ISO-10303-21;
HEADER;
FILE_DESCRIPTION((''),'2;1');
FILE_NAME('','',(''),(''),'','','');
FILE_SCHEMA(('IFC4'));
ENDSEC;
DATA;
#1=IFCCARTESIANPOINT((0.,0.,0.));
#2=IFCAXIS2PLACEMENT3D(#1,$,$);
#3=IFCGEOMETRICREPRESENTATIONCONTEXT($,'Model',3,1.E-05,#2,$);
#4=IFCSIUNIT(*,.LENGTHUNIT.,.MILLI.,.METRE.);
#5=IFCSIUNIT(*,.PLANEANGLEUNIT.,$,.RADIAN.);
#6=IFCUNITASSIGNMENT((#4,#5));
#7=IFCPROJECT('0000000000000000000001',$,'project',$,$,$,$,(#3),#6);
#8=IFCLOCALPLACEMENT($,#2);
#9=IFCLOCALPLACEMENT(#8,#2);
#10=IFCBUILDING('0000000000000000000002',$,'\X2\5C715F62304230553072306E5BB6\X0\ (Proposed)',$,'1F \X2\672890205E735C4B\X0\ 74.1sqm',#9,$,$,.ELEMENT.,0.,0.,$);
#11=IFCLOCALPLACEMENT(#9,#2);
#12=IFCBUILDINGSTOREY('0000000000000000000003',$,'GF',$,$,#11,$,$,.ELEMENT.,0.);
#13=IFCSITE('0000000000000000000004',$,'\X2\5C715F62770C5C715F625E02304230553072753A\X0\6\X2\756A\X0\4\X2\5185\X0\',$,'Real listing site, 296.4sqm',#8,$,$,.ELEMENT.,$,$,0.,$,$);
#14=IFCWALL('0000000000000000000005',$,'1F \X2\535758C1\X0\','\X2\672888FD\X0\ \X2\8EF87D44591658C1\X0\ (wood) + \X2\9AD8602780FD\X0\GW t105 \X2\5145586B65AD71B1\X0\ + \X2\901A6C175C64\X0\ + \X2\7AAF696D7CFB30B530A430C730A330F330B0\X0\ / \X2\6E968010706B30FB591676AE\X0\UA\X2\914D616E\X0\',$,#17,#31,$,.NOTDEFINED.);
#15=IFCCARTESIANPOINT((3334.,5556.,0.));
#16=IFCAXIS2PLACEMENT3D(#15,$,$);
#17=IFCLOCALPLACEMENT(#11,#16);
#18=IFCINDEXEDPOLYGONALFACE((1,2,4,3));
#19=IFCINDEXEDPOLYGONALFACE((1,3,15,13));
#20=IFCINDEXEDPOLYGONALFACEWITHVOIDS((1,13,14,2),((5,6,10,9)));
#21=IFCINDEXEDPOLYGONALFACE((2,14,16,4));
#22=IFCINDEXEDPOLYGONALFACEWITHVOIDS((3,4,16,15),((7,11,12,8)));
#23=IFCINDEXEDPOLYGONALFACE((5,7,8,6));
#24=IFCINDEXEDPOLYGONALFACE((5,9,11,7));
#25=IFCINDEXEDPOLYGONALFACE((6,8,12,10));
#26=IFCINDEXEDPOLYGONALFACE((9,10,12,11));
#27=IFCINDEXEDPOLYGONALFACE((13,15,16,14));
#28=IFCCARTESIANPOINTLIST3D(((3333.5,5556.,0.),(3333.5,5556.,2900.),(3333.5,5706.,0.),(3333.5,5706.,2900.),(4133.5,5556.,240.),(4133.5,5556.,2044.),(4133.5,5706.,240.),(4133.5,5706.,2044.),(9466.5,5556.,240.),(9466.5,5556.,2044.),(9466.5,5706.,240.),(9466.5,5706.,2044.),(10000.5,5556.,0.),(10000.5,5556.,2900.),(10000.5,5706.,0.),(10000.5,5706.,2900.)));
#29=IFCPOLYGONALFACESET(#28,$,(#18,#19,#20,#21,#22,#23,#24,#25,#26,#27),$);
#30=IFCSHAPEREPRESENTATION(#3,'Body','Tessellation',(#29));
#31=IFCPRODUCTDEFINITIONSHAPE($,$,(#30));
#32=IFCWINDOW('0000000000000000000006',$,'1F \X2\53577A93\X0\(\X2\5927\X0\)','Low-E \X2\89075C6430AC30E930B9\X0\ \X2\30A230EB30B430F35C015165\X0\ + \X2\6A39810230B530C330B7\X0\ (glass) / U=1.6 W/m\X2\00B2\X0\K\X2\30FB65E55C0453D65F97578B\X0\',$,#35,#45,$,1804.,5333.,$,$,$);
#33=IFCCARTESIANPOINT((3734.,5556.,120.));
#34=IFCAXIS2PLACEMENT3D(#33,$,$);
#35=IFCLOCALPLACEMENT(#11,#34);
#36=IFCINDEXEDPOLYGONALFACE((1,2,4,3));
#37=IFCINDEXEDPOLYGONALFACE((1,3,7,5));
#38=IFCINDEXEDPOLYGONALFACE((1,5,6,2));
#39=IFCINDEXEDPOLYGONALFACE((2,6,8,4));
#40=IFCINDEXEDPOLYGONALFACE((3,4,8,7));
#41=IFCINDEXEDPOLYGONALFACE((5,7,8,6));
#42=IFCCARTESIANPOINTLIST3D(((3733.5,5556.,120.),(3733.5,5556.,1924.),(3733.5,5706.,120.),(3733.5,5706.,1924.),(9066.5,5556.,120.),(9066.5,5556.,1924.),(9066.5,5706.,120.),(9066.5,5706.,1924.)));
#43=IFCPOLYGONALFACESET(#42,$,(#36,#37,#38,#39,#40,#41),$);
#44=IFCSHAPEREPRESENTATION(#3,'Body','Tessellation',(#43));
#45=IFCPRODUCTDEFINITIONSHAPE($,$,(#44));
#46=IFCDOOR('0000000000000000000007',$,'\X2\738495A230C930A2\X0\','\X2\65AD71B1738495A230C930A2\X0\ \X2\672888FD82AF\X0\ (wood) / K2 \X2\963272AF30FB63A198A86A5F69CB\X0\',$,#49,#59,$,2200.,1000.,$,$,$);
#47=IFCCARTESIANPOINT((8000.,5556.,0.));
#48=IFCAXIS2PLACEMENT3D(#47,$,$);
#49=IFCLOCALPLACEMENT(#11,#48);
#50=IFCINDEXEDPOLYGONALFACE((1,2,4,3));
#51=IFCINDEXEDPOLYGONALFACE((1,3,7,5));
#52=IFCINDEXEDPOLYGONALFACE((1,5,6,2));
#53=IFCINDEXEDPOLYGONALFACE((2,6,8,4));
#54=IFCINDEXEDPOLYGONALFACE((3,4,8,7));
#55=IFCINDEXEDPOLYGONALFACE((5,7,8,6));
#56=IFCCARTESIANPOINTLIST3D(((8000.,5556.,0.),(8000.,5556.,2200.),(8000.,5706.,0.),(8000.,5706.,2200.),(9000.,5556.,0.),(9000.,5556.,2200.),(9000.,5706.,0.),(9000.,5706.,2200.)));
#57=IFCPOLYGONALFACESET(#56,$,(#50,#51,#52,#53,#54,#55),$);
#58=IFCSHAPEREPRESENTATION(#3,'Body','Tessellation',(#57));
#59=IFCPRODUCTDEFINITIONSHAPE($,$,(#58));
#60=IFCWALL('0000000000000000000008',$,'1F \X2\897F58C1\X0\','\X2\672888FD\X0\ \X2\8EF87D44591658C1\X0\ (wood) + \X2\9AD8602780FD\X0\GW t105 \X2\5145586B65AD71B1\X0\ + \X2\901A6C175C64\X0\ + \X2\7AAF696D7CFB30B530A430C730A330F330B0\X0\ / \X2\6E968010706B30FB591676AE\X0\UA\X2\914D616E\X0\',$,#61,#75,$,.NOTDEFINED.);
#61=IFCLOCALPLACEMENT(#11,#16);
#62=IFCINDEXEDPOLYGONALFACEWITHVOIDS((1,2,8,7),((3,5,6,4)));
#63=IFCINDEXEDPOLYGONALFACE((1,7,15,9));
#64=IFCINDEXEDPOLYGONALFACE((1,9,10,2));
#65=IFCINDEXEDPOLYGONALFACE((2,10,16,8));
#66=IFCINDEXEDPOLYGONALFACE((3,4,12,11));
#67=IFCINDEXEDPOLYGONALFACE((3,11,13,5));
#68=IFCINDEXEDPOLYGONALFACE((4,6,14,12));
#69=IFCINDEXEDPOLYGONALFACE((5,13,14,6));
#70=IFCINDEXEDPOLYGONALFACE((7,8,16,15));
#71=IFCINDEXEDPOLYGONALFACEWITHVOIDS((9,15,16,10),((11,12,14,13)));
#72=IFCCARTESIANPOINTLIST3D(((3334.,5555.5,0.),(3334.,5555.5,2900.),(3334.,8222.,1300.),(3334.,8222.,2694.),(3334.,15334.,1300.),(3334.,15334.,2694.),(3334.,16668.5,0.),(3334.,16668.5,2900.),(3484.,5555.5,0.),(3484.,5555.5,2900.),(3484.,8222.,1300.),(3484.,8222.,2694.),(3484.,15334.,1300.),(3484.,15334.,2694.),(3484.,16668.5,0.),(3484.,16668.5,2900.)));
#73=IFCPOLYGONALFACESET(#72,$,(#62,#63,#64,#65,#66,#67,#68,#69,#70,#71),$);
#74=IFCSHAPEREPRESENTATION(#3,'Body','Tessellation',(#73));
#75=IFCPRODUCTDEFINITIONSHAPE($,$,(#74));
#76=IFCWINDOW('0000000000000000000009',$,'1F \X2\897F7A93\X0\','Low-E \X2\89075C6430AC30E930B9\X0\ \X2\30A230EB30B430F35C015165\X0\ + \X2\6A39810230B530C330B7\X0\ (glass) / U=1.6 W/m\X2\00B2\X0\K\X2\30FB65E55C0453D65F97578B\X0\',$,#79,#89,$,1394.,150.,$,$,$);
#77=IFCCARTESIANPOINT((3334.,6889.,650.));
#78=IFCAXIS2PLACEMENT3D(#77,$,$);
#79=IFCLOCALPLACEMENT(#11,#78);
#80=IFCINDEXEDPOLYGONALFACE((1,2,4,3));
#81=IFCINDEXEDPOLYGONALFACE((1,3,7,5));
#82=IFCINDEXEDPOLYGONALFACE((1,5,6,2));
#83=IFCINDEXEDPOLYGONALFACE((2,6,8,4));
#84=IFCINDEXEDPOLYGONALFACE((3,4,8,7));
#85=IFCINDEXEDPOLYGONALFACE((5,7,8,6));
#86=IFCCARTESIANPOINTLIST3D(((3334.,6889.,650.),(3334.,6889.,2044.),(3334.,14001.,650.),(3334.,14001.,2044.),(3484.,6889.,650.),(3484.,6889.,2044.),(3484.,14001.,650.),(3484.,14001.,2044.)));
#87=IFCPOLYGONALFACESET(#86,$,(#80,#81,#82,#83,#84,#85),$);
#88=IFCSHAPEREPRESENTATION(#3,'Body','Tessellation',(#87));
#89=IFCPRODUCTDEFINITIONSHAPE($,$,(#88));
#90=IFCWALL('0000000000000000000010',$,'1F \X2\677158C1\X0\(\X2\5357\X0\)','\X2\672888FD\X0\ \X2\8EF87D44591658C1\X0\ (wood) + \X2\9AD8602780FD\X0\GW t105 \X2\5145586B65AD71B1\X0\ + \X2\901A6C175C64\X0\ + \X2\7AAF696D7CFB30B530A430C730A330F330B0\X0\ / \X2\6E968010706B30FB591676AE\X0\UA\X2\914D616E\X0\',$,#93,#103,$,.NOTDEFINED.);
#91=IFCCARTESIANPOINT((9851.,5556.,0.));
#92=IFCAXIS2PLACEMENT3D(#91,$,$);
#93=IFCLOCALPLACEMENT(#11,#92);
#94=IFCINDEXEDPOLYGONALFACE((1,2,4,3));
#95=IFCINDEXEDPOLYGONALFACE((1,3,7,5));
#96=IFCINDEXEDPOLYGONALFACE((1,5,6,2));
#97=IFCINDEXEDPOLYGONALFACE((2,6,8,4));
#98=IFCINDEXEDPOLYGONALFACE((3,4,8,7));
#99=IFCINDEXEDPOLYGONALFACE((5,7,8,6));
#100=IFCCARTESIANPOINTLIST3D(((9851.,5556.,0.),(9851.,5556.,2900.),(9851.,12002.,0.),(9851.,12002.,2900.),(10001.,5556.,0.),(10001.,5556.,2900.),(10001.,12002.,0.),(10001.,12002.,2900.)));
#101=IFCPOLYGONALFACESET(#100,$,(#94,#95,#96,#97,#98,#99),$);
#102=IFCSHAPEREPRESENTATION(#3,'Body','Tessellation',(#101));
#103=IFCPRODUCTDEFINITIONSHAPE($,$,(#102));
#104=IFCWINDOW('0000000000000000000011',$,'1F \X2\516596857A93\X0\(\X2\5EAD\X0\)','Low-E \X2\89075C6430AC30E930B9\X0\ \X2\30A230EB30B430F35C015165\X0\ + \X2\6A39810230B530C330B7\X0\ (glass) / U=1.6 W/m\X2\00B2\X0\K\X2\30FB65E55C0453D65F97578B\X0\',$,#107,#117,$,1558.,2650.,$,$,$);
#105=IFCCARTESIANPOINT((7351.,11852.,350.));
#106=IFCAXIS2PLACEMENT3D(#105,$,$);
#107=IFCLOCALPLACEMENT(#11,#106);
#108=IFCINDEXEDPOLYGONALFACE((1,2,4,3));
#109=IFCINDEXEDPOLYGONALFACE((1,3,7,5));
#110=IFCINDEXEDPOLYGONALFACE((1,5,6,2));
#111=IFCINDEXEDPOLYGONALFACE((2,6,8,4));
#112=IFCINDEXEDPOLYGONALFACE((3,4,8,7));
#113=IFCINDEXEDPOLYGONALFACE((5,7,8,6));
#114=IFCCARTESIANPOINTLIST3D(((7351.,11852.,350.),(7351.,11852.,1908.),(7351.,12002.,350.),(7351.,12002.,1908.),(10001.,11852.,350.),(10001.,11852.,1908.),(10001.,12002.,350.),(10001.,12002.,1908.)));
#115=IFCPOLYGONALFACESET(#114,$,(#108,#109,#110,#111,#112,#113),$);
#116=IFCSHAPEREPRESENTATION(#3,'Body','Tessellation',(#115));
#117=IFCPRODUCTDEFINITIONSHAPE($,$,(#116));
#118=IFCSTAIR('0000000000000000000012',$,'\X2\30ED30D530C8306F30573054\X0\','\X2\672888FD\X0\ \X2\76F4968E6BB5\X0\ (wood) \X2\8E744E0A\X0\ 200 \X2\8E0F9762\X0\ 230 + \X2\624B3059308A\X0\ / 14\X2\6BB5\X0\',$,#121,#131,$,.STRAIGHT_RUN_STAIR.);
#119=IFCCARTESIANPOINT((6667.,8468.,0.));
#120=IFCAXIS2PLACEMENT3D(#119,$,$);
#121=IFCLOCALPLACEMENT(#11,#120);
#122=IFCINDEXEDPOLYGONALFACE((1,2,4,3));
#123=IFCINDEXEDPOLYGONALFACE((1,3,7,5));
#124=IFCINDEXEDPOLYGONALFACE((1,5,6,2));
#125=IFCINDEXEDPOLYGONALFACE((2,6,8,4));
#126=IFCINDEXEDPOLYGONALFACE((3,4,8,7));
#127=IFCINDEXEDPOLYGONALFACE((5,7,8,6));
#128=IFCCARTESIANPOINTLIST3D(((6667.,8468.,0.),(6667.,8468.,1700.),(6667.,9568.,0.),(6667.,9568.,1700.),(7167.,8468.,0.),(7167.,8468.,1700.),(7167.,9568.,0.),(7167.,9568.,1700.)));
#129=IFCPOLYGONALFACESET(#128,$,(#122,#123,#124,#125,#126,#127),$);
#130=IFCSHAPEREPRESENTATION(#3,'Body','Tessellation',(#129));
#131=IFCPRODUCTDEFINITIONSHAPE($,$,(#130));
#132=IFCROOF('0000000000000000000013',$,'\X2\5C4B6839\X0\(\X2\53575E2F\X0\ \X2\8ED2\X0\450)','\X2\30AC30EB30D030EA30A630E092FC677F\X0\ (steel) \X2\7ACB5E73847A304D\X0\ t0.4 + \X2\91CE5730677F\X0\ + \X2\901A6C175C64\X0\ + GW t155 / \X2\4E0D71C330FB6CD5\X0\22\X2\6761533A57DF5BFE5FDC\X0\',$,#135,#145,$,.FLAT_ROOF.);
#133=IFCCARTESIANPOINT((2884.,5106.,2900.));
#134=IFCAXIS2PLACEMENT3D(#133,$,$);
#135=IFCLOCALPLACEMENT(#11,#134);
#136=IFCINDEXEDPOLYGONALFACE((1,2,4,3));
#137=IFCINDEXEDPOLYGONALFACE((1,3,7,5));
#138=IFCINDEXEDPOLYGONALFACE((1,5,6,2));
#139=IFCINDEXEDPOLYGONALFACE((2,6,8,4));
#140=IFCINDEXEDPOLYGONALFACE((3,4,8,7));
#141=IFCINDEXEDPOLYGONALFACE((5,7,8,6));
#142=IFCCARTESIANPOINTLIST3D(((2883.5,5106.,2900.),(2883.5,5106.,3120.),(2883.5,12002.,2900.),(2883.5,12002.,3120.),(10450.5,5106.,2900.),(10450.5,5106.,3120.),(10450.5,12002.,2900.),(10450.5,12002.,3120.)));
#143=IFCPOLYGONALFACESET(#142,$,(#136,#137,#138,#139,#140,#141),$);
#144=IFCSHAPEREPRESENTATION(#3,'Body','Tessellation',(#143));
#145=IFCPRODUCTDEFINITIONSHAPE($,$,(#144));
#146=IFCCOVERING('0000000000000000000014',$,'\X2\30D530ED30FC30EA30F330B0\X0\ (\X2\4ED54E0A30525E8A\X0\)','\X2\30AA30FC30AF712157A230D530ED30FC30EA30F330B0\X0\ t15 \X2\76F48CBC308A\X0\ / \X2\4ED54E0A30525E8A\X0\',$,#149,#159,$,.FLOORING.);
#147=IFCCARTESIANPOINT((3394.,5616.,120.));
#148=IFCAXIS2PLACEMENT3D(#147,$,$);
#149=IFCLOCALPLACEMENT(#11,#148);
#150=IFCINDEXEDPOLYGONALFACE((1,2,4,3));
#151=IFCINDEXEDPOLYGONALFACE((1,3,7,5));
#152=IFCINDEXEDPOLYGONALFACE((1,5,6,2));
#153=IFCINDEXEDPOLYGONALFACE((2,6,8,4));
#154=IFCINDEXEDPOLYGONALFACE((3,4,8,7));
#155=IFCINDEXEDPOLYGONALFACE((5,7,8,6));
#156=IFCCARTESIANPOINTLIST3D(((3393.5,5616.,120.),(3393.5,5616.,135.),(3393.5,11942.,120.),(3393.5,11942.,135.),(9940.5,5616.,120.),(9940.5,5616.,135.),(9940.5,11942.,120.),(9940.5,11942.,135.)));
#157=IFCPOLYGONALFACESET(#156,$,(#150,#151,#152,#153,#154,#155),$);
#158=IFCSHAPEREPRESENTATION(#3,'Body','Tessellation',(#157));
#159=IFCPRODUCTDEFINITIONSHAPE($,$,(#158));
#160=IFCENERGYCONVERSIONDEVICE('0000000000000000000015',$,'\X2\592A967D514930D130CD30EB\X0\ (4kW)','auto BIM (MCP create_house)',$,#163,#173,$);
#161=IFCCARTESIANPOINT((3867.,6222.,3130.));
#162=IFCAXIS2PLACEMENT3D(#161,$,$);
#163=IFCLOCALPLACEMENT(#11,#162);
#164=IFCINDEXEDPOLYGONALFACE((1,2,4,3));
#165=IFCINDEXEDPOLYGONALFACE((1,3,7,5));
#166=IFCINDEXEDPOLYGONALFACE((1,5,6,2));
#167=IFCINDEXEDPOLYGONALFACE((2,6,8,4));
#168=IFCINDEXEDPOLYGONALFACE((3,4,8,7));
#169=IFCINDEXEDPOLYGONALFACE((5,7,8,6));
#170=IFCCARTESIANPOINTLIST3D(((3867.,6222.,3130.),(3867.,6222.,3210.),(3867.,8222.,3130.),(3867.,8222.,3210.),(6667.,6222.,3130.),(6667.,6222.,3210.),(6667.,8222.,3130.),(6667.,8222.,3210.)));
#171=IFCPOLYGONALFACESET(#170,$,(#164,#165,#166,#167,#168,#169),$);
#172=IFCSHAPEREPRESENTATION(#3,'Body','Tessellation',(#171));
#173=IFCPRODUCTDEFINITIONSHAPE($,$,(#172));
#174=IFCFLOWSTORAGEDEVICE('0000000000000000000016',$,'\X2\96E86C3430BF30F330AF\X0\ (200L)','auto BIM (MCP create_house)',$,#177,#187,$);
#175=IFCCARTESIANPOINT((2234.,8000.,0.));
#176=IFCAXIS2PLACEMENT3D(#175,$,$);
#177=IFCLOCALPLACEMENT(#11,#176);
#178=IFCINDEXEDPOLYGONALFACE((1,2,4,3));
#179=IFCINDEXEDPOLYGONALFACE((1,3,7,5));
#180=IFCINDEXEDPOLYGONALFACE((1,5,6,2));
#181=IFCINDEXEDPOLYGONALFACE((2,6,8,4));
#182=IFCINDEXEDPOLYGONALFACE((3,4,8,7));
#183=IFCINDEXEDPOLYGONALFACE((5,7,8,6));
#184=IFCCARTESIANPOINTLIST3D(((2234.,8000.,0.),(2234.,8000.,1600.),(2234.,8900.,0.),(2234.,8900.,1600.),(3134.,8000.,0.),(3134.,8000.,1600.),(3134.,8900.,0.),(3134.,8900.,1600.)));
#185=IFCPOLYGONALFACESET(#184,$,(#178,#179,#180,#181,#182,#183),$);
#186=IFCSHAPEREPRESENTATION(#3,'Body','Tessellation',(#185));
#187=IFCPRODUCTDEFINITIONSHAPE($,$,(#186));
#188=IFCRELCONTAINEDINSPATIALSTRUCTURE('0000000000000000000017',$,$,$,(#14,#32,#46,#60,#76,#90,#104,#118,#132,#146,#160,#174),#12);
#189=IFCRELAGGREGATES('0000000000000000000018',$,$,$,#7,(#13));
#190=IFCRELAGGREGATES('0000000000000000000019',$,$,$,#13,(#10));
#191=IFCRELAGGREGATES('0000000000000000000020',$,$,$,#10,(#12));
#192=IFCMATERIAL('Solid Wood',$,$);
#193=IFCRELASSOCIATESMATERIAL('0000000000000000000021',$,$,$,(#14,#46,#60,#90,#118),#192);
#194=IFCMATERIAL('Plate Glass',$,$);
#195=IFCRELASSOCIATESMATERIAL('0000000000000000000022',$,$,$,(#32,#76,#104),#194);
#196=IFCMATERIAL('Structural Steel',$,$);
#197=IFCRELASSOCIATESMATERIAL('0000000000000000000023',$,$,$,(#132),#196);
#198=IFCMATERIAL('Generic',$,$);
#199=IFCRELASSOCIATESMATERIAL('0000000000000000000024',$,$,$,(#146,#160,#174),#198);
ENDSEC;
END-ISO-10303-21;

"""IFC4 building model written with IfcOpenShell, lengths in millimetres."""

from ifc_helpers import new_model, si_unit, frame, frame_2d, origin, place, context, project, spatial, rectangle, extrude, material, element, fill, save


model = new_model("IFC4")

# Units and contexts
model_context = context("Model", 3, precision=1e-05, world=origin())
ifc_project = project(units=[si_unit("LENGTHUNIT", "METRE", prefix="MILLI"), si_unit("PLANEANGLEUNIT", "RADIAN")], contexts=[model_context])

# Site, building, storey
site_placement = place(None, origin())
site = spatial("IfcSite", under=ifc_project, at=site_placement, Name="山形県山形市あさひ町6番4内", ObjectType="Real listing site, 296.4sqm", CompositionType="ELEMENT", RefElevation=0.0)
building_placement = place(site_placement, origin())
building = spatial("IfcBuilding", under=site, at=building_placement, Name="山形あさひの家 (Proposed)", ObjectType="1F 木造平屋 74.1sqm", CompositionType="ELEMENT", ElevationOfRefHeight=0.0, ElevationOfTerrain=0.0)
storey_placement = place(building_placement, origin())
storey = spatial("IfcBuildingStorey", under=building, at=storey_placement, Name="GF", CompositionType="ELEMENT", Elevation=0.0)

# Shared definitions
ifc_material_1 = material(Name="Solid Wood")

# Wall, openings, window, door
wall_1_placement = place(storey_placement, frame((3334.0, 5556.0, 0.0)))
wall_1 = element("IfcWall", 1, at=wall_1_placement, inside=storey, material=ifc_material_1, Name="1F 南壁", Description="木製 軸組外壁 (wood) + 高性能GW t105 充填断熱 + 通気層 + 窯業系サイディング / 準耐火・外皮UA配慮", PredefinedType="NOTDEFINED", context=model_context, shape_type="SweptSolid", body=[
    extrude(rectangle(XDim=6667.0, YDim=150.0, at=frame_2d((3333.0, 75.0))), frame((3334.0, 5556.0, 0.0)), (0.0, 0.0, 1.0), 2900.0),
])
opening_1_placement = place(storey_placement, frame((3734.0, 5556.0, 120.0)))
opening_1 = element("IfcOpeningElement", 2, at=opening_1_placement, cuts=wall_1, PredefinedType="NOTDEFINED", context=model_context, shape_type="SweptSolid", body=[
    extrude(rectangle(XDim=5333.0, YDim=150.0, at=frame_2d((2666.0, 75.0))), frame((3734.0, 5556.0, 120.0)), (0.0, 0.0, 1.0), 1804.0),
])
opening_2_placement = place(storey_placement, frame((8000.0, 5556.0, 0.0)))
opening_2 = element("IfcOpeningElement", 3, at=opening_2_placement, cuts=wall_1, PredefinedType="NOTDEFINED", context=model_context, shape_type="SweptSolid", body=[
    extrude(rectangle(XDim=1000.0, YDim=150.0, at=frame_2d((500.0, 75.0))), frame((8000.0, 5556.0, 0.0)), (0.0, 0.0, 1.0), 2200.0),
])
ifc_material_2 = material(Name="Plate Glass")
window_1_placement = place(storey_placement, frame((3734.0, 5556.0, 120.0)))
window_1 = element("IfcWindow", 4, at=window_1_placement, inside=storey, material=ifc_material_2, Name="1F 南窓(大)", Description="Low-E 複層ガラス アルゴン封入 + 樹脂サッシ (glass) / U=1.6 W/m²K・日射取得型", OverallHeight=1804.0, OverallWidth=5333.0, context=model_context, shape_type="SweptSolid", body=[
    extrude(rectangle(XDim=5333.0, YDim=150.0, at=frame_2d((2666.0, 75.0))), frame((3734.0, 5556.0, 120.0)), (0.0, 0.0, 1.0), 1804.0),
])
fill(opening_1, window_1)
door_1_placement = place(storey_placement, frame((8000.0, 5556.0, 0.0)))
door_1 = element("IfcDoor", 5, at=door_1_placement, inside=storey, material=ifc_material_1, Name="玄関ドア", Description="断熱玄関ドア 木製芯 (wood) / K2 防犯・採風機構", OverallHeight=2200.0, OverallWidth=1000.0, context=model_context, shape_type="SweptSolid", body=[
    extrude(rectangle(XDim=1000.0, YDim=150.0, at=frame_2d((500.0, 75.0))), frame((8000.0, 5556.0, 0.0)), (0.0, 0.0, 1.0), 2200.0),
])
fill(opening_2, door_1)

# Walls, openings, windows
wall_2_placement = place(storey_placement, frame((3334.0, 5556.0, 0.0)))
wall_2 = element("IfcWall", 6, at=wall_2_placement, inside=storey, material=ifc_material_1, Name="1F 西壁", Description="木製 軸組外壁 (wood) + 高性能GW t105 充填断熱 + 通気層 + 窯業系サイディング / 準耐火・外皮UA配慮", PredefinedType="NOTDEFINED", context=model_context, shape_type="SweptSolid", body=[
    extrude(rectangle(XDim=150.0, YDim=11113.0, at=frame_2d((75.0, 5556.0))), frame((3334.0, 5556.0, 0.0)), (0.0, 0.0, 1.0), 2900.0),
])
opening_3_placement = place(storey_placement, frame((3334.0, 6889.0, 650.0)))
opening_3 = element("IfcOpeningElement", 7, at=opening_3_placement, cuts=wall_2, PredefinedType="NOTDEFINED", context=model_context, shape_type="SweptSolid", body=[
    extrude(rectangle(XDim=150.0, YDim=7112.0, at=frame_2d((75.0, 3556.0))), frame((3334.0, 6889.0, 650.0)), (0.0, 0.0, 1.0), 1394.0),
])
window_2_placement = place(storey_placement, frame((3334.0, 6889.0, 650.0)))
window_2 = element("IfcWindow", 8, at=window_2_placement, inside=storey, material=ifc_material_2, Name="1F 西窓", Description="Low-E 複層ガラス アルゴン封入 + 樹脂サッシ (glass) / U=1.6 W/m²K・日射取得型", OverallHeight=1394.0, OverallWidth=150.0, context=model_context, shape_type="SweptSolid", body=[
    extrude(rectangle(XDim=150.0, YDim=7112.0, at=frame_2d((75.0, 3556.0))), frame((3334.0, 6889.0, 650.0)), (0.0, 0.0, 1.0), 1394.0),
])
fill(opening_3, window_2)
wall_3_placement = place(storey_placement, frame((9851.0, 5556.0, 0.0)))
wall_3 = element("IfcWall", 9, at=wall_3_placement, inside=storey, material=ifc_material_1, Name="1F 東壁(南)", Description="木製 軸組外壁 (wood) + 高性能GW t105 充填断熱 + 通気層 + 窯業系サイディング / 準耐火・外皮UA配慮", PredefinedType="NOTDEFINED", context=model_context, shape_type="SweptSolid", body=[
    extrude(rectangle(XDim=150.0, YDim=6446.0, at=frame_2d((75.0, 3223.0))), frame((9851.0, 5556.0, 0.0)), (0.0, 0.0, 1.0), 2900.0),
])
opening_4_placement = place(storey_placement, frame((7351.0, 11852.0, 350.0)))
opening_4 = element("IfcOpeningElement", 10, at=opening_4_placement, cuts=wall_3, PredefinedType="NOTDEFINED", context=model_context, shape_type="SweptSolid", body=[
    extrude(rectangle(XDim=2650.0, YDim=150.0, at=frame_2d((1325.0, 75.0))), frame((7351.0, 11852.0, 350.0)), (0.0, 0.0, 1.0), 1558.0),
])
window_3_placement = place(storey_placement, frame((7351.0, 11852.0, 350.0)))
window_3 = element("IfcWindow", 11, at=window_3_placement, inside=storey, material=ifc_material_2, Name="1F 入隅窓(庭)", Description="Low-E 複層ガラス アルゴン封入 + 樹脂サッシ (glass) / U=1.6 W/m²K・日射取得型", OverallHeight=1558.0, OverallWidth=2650.0, context=model_context, shape_type="SweptSolid", body=[
    extrude(rectangle(XDim=2650.0, YDim=150.0, at=frame_2d((1325.0, 75.0))), frame((7351.0, 11852.0, 350.0)), (0.0, 0.0, 1.0), 1558.0),
])
fill(opening_4, window_3)

# Stair
stair_placement = place(storey_placement, frame((6667.0, 8468.0, 0.0)))
element("IfcStair", 12, at=stair_placement, inside=storey, material=ifc_material_1, Name="ロフトはしご", Description="木製 直階段 (wood) 蹴上 200 踏面 230 + 手すり / 14段", PredefinedType="STRAIGHT_RUN_STAIR", context=model_context, shape_type="SweptSolid", body=[
    extrude(rectangle(XDim=500.0, YDim=1100.0, at=frame_2d((250.0, 550.0))), frame((6667.0, 8468.0, 0.0)), (0.0, 0.0, 1.0), 1700.0),
])

# Roof
ifc_material_3 = material(Name="Structural Steel")
roof_placement = place(storey_placement, frame((2884.0, 5106.0, 2900.0)))
element("IfcRoof", 13, at=roof_placement, inside=storey, material=ifc_material_3, Name="屋根(南帯 軒450)", Description="ガルバリウム鋼板 (steel) 立平葺き t0.4 + 野地板 + 通気層 + GW t155 / 不燃・法22条区域対応", PredefinedType="FLAT_ROOF", context=model_context, shape_type="SweptSolid", body=[
    extrude(rectangle(XDim=7567.0, YDim=6896.0, at=frame_2d((3783.0, 3448.0))), frame((2884.0, 5106.0, 2900.0)), (0.0, 0.0, 1.0), 220.0),
])

# Covering
ifc_material_4 = material(Name="Generic")
covering_placement = place(storey_placement, frame((3394.0, 5616.0, 120.0)))
element("IfcCovering", 14, at=covering_placement, inside=storey, material=ifc_material_4, Name="フローリング (仕上げ床)", Description="オーク無垢フローリング t15 直貼り / 仕上げ床", PredefinedType="FLOORING", context=model_context, shape_type="SweptSolid", body=[
    extrude(rectangle(XDim=6547.0, YDim=6326.0, at=frame_2d((3273.0, 3163.0))), frame((3394.0, 5616.0, 120.0)), (0.0, 0.0, 1.0), 15.0),
])

# Energy conversion device
energy_conversion_device_placement = place(storey_placement, frame((3867.0, 6222.0, 3130.0)))
element("IfcEnergyConversionDevice", 15, at=energy_conversion_device_placement, inside=storey, material=ifc_material_4, Name="太陽光パネル (4kW)", Description="auto BIM (MCP create_house)", context=model_context, shape_type="SweptSolid", body=[
    extrude(rectangle(XDim=2800.0, YDim=2000.0, at=frame_2d((1400.0, 1000.0))), frame((3867.0, 6222.0, 3130.0)), (0.0, 0.0, 1.0), 80.0),
])

# Flow storage device
flow_storage_device_placement = place(storey_placement, frame((2234.0, 8000.0, 0.0)))
element("IfcFlowStorageDevice", 16, at=flow_storage_device_placement, inside=storey, material=ifc_material_4, Name="雨水タンク (200L)", Description="auto BIM (MCP create_house)", context=model_context, shape_type="SweptSolid", body=[
    extrude(rectangle(XDim=900.0, YDim=900.0, at=frame_2d((450.0, 450.0))), frame((2234.0, 8000.0, 0.0)), (0.0, 0.0, 1.0), 1600.0),
])

save(model, "model.ifc")
